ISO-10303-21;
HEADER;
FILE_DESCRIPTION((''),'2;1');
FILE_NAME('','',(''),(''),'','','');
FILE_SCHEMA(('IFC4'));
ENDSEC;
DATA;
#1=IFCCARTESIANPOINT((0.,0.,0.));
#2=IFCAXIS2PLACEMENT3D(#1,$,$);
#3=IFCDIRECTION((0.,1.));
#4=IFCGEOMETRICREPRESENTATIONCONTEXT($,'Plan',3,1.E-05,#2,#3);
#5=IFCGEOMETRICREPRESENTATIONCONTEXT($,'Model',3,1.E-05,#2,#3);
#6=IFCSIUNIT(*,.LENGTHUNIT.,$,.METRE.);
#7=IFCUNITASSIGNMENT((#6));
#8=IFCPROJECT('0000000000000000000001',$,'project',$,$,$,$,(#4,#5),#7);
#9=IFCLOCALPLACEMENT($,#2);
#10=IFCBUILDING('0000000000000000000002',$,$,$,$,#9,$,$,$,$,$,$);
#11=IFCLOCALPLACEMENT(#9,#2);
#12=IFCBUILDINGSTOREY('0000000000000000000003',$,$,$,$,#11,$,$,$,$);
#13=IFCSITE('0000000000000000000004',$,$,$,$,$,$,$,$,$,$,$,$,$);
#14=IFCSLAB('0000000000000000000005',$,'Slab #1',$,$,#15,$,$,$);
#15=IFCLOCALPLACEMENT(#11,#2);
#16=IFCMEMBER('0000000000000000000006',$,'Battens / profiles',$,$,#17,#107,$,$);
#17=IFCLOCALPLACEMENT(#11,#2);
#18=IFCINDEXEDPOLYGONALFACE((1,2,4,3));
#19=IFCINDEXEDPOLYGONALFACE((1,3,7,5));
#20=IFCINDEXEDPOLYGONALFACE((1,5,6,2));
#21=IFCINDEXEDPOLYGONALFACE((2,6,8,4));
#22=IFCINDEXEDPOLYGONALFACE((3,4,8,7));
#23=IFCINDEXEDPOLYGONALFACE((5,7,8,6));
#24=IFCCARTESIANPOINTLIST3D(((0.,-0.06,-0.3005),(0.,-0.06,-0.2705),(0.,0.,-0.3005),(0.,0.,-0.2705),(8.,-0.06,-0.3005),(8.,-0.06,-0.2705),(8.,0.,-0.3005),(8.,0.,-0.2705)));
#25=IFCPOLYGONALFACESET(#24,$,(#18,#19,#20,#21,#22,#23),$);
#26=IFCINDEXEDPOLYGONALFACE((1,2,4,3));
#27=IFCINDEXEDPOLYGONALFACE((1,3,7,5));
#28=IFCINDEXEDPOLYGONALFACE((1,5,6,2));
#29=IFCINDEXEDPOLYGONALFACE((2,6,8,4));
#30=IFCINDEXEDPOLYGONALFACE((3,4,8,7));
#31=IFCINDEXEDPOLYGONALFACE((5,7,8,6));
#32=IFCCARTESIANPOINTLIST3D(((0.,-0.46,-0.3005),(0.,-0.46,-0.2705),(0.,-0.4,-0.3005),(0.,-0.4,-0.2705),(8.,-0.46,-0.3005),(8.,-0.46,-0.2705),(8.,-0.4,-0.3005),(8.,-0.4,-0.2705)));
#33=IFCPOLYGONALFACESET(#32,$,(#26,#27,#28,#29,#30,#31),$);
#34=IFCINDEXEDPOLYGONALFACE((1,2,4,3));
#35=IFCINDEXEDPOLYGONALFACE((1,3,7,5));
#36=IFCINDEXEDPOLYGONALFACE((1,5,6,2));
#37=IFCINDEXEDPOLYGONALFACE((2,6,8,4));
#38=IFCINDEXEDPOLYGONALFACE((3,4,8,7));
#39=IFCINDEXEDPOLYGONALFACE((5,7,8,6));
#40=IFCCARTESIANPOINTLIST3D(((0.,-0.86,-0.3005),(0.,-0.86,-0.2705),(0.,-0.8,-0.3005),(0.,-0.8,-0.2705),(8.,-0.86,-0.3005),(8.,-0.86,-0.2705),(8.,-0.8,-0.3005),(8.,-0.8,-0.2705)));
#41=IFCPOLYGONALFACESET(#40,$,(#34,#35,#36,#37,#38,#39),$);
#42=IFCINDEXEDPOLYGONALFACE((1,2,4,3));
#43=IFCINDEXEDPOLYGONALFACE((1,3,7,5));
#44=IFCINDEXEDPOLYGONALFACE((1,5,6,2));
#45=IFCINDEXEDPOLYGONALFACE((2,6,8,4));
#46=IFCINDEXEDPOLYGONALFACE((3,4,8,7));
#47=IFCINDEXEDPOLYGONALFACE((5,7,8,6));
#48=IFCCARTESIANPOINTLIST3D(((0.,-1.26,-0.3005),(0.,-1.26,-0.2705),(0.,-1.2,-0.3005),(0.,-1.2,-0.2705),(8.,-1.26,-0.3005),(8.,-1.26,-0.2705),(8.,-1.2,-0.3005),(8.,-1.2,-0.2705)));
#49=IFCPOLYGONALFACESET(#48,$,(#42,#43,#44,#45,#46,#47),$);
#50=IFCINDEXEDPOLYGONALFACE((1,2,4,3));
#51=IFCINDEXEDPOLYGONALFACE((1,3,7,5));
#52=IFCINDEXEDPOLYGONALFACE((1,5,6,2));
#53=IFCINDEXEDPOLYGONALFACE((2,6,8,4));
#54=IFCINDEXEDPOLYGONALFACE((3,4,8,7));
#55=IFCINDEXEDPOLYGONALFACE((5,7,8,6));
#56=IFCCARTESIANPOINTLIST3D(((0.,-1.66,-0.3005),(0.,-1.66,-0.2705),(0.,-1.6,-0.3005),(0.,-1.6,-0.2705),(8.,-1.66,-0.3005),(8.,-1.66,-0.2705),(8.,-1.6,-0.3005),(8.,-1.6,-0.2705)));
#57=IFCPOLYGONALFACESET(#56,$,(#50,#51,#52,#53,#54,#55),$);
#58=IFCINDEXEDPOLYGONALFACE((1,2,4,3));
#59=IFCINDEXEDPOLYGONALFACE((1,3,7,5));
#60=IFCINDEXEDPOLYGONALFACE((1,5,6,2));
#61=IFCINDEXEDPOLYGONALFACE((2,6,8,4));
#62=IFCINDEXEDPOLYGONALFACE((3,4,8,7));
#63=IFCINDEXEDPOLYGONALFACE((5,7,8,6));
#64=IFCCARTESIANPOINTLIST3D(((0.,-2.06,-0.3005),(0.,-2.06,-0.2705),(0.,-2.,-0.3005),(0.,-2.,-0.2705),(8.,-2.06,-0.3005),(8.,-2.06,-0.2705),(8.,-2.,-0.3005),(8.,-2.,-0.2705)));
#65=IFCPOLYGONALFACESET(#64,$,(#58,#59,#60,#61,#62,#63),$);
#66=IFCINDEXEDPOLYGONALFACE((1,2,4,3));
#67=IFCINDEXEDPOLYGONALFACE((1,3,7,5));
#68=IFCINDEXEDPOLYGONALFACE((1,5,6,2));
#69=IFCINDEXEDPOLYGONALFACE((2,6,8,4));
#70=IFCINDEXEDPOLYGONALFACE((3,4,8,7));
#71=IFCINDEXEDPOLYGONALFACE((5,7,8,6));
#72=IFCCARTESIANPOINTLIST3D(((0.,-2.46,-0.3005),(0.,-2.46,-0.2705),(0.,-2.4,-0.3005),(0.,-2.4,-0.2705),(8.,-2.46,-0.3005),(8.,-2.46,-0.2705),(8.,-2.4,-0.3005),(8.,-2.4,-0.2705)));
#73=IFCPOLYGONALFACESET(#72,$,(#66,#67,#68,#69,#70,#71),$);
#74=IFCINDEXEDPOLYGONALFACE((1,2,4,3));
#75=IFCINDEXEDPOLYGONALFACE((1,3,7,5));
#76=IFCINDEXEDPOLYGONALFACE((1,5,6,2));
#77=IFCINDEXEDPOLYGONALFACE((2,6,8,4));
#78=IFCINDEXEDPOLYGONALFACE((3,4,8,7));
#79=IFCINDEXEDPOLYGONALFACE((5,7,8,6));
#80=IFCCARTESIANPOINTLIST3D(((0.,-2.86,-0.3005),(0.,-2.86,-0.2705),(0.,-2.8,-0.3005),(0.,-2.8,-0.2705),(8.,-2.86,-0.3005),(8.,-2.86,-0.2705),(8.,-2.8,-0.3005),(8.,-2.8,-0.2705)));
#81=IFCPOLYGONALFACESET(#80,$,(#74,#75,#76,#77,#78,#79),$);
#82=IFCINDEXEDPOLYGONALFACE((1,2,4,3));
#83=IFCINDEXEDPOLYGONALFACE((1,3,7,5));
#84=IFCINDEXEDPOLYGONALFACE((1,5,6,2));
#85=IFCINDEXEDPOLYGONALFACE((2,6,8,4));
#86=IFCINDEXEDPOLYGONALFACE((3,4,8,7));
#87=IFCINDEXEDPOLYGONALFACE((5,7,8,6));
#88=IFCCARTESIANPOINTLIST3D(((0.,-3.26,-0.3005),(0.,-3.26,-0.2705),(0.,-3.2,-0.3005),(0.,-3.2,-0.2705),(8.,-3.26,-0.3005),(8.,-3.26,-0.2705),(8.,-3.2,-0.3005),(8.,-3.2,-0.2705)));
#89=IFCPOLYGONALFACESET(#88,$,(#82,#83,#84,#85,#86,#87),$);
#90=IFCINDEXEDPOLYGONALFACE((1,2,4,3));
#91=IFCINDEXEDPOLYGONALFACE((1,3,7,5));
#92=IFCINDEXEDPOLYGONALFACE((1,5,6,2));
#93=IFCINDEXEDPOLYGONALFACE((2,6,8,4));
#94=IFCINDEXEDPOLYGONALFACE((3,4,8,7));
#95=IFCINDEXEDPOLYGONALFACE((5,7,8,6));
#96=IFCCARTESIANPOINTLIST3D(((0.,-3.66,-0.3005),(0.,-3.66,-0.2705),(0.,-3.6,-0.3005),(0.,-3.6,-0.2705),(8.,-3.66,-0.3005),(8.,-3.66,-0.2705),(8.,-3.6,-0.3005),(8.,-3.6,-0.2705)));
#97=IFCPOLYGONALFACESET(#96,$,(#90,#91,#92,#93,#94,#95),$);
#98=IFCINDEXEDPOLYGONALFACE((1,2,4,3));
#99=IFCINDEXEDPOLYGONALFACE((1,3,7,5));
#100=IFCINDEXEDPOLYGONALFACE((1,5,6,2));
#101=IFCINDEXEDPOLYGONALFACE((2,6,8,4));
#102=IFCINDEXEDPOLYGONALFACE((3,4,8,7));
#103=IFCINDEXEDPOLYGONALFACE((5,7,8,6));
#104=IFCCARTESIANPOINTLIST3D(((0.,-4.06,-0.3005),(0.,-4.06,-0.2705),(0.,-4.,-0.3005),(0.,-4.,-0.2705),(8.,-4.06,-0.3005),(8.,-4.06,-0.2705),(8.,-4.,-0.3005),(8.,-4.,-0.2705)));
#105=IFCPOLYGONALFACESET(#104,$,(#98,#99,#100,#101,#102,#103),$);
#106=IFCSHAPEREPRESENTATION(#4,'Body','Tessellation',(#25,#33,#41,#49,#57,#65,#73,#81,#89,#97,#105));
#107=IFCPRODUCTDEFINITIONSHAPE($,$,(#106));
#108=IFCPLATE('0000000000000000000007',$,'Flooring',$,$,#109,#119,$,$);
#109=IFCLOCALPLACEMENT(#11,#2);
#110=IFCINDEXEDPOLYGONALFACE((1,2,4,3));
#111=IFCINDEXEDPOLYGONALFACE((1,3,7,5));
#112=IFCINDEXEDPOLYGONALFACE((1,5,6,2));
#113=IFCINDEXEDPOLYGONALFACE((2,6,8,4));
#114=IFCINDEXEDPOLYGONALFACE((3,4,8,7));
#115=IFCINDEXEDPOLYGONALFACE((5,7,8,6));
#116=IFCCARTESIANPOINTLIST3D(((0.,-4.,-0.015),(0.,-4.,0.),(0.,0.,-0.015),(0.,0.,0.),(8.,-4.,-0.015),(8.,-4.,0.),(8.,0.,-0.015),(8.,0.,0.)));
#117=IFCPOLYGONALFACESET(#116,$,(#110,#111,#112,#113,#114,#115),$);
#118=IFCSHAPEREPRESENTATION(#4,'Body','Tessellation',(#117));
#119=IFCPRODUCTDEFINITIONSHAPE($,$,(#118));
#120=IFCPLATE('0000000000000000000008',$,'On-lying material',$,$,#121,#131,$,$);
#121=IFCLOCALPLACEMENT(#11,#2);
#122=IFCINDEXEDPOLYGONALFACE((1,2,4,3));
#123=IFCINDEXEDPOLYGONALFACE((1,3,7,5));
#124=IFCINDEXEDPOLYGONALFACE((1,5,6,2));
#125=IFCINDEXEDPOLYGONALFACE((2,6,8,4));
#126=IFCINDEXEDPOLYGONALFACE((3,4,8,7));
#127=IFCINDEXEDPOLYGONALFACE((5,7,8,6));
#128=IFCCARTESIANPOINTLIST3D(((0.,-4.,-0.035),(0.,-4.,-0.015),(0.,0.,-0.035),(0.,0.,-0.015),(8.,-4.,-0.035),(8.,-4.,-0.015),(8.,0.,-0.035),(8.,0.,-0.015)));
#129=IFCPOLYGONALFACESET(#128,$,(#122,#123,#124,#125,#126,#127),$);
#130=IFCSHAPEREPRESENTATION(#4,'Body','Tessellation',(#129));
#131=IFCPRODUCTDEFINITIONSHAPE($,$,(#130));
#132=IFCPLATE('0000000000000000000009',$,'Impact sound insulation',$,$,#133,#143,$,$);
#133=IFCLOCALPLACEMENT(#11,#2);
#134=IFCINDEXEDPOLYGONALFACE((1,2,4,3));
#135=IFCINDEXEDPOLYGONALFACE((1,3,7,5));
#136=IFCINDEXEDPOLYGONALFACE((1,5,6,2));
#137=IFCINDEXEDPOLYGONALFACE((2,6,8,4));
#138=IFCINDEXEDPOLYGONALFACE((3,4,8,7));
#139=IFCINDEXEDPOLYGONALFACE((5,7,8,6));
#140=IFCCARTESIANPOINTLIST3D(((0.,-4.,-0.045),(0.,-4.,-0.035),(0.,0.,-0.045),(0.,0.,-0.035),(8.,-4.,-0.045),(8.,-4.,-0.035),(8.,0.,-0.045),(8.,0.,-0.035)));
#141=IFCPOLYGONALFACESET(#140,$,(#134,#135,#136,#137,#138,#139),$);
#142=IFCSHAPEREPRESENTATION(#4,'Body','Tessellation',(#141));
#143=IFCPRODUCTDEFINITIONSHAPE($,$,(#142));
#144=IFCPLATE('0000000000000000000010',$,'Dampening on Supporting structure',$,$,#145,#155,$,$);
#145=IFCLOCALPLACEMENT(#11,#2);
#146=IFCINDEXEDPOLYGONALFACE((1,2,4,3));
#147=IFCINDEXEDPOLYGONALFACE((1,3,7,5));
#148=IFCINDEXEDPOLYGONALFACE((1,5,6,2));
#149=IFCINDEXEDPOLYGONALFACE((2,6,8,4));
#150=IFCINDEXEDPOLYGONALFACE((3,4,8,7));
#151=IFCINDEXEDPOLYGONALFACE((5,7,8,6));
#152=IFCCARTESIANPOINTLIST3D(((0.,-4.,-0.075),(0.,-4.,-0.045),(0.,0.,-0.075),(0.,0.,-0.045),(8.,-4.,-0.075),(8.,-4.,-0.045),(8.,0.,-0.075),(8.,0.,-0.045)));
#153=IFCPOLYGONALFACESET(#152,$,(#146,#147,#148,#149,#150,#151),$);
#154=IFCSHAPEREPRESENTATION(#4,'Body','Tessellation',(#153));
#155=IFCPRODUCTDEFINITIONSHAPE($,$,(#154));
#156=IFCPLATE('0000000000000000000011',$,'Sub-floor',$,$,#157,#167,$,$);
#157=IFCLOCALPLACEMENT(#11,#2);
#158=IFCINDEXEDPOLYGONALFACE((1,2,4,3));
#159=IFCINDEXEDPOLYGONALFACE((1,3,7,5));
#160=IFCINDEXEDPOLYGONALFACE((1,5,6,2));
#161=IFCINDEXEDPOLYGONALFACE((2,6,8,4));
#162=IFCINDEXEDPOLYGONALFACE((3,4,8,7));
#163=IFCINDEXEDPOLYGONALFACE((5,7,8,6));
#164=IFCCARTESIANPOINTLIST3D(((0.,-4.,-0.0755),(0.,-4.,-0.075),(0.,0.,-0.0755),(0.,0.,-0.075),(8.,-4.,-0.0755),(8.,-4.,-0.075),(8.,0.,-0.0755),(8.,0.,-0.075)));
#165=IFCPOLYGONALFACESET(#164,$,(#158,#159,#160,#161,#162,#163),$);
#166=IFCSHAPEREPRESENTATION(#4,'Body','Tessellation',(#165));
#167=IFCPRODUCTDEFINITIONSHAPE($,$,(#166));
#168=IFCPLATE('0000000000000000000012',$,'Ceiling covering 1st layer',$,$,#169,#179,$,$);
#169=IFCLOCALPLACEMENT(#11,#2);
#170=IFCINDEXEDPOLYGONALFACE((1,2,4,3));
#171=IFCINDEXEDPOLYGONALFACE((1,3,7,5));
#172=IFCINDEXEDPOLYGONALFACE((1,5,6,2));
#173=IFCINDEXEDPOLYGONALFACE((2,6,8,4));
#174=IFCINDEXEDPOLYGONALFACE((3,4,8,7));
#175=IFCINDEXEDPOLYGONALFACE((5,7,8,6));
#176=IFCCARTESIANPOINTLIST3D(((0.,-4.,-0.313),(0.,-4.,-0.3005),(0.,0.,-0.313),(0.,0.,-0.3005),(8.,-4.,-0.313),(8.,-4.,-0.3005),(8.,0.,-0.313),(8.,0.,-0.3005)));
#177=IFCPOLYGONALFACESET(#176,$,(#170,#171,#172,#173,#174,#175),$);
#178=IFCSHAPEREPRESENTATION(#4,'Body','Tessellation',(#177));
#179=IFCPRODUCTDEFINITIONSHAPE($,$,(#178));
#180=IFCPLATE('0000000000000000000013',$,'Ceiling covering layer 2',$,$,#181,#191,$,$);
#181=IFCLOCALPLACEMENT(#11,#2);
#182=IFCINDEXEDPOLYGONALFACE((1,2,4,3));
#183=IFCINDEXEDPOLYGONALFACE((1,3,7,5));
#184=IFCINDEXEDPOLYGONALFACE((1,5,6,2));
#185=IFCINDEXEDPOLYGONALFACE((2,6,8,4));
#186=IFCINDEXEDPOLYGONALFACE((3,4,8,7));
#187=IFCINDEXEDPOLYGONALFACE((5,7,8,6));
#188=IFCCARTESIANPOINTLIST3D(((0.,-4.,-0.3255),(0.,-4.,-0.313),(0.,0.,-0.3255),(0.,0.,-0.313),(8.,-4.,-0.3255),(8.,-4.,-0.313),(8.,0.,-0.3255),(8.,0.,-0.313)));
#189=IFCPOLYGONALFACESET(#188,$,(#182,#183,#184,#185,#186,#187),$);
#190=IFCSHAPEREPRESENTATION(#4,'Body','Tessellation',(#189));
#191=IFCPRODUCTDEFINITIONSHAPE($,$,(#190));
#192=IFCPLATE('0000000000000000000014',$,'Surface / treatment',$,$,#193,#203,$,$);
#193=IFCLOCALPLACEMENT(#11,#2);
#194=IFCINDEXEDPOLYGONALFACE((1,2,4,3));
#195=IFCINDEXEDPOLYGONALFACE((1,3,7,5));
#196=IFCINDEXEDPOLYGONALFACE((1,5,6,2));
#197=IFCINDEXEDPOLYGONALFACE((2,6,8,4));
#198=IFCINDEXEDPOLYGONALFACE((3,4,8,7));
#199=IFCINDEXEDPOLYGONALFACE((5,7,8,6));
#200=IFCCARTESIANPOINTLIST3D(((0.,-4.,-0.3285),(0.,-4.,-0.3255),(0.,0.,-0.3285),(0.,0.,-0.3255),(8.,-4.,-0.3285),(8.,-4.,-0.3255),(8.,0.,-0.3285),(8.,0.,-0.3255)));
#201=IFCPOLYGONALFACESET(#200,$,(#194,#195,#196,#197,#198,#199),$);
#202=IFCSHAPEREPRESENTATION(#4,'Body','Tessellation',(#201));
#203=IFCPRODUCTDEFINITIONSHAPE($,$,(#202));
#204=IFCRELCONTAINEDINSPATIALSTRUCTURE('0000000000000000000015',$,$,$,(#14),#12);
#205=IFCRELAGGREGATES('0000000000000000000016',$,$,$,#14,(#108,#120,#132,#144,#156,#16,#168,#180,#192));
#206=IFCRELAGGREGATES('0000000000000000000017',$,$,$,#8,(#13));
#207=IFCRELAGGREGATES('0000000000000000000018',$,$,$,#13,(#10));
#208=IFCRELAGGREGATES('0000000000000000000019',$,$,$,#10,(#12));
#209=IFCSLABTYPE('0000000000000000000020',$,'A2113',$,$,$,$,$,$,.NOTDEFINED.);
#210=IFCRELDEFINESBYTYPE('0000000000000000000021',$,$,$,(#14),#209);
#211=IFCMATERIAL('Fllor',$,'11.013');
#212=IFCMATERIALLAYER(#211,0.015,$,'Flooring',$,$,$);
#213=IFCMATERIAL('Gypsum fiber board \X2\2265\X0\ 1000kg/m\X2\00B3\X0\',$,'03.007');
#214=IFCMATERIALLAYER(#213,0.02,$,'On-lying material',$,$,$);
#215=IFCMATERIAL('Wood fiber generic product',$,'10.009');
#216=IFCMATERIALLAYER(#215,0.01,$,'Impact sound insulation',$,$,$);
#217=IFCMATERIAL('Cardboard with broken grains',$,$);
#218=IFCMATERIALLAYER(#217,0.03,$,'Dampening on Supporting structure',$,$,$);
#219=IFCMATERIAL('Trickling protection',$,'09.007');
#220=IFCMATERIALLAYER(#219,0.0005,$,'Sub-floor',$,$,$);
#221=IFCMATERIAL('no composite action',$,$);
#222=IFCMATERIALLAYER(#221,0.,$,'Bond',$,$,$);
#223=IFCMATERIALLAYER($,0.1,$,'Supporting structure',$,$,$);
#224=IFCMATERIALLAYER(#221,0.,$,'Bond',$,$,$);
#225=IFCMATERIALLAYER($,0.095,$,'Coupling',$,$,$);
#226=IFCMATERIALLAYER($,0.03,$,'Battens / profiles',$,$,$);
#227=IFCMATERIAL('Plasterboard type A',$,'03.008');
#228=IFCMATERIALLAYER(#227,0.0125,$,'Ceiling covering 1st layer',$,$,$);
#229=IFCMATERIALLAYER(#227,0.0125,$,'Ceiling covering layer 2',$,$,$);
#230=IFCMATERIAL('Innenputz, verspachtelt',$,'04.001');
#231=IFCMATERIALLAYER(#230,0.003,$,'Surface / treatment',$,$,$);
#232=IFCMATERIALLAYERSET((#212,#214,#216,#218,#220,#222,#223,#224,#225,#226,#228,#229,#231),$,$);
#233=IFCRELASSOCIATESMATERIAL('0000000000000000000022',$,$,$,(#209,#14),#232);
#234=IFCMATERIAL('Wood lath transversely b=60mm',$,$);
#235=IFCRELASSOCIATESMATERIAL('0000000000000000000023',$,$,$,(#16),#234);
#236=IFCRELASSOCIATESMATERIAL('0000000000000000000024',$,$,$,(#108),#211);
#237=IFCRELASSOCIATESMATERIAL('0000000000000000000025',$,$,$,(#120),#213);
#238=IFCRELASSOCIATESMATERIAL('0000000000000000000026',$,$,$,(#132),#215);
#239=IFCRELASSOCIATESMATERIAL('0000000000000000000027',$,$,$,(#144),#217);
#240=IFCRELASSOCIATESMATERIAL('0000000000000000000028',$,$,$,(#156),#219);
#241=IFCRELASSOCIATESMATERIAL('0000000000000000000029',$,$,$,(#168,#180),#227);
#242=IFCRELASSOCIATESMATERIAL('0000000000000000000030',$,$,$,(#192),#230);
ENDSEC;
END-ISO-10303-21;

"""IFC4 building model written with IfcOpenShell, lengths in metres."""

from ifc_helpers import new_model, si_unit, direction, frame, frame_2d, origin, origin_with_axes, place, context, project, spatial, rectangle, extrude, material, layer, layer_set, type_object, element, aggregate, save


model = new_model("IFC4")

# Units and contexts
plan_context = context("Plan", 3, precision=1e-05, world=origin(), true_north=direction((0.0, 1.0)))
model_context = context("Model", 3, precision=1e-05, world=origin(), true_north=direction((0.0, 1.0)))
ifc_project = project(units=[si_unit("LENGTHUNIT", "METRE")], contexts=[plan_context, model_context])

# Site, building, storey
site = spatial("IfcSite", under=ifc_project)
building_placement = place(None, origin())
building = spatial("IfcBuilding", under=site, at=building_placement)
storey_placement = place(building_placement, origin())
storey = spatial("IfcBuildingStorey", under=building, at=storey_placement)

# Slab, member, plates
ifc_material_1 = material(Name="Fllor", Category="11.013")
ifc_layer_1 = layer(ifc_material_1, 0.015, Name="Flooring")
ifc_material_2 = material(Name="Gypsum fiber board ≥ 1000kg/m³", Category="03.007")
ifc_layer_2 = layer(ifc_material_2, 0.02, Name="On-lying material")
ifc_material_3 = material(Name="Wood fiber generic product", Category="10.009")
ifc_layer_3 = layer(ifc_material_3, 0.01, Name="Impact sound insulation")
ifc_material_4 = material(Name="Cardboard with broken grains")
ifc_layer_4 = layer(ifc_material_4, 0.03, Name="Dampening on Supporting structure")
ifc_material_5 = material(Name="Trickling protection", Category="09.007")
ifc_layer_5 = layer(ifc_material_5, 0.0005, Name="Sub-floor")
ifc_material_6 = material(Name="no composite action")
ifc_layer_6 = layer(ifc_material_6, 0.0, Name="Bond")
ifc_layer_7 = layer(None, 0.1, Name="Supporting structure")
ifc_layer_8 = layer(ifc_material_6, 0.0, Name="Bond")
ifc_layer_9 = layer(None, 0.095, Name="Coupling")
ifc_layer_10 = layer(None, 0.03, Name="Battens / profiles")
ifc_material_7 = material(Name="Plasterboard type A", Category="03.008")
ifc_layer_11 = layer(ifc_material_7, 0.0125, Name="Ceiling covering 1st layer")
ifc_layer_12 = layer(ifc_material_7, 0.0125, Name="Ceiling covering layer 2")
ifc_material_8 = material(Name="Innenputz, verspachtelt", Category="04.001")
ifc_layer_13 = layer(ifc_material_8, 0.003, Name="Surface / treatment")
ifc_layer_set = layer_set([ifc_layer_1, ifc_layer_2, ifc_layer_3, ifc_layer_4, ifc_layer_5, ifc_layer_6, ifc_layer_7, ifc_layer_8, ifc_layer_9, ifc_layer_10, ifc_layer_11, ifc_layer_12, ifc_layer_13])
slab_type = type_object("IfcSlabType", Name="A2113", PredefinedType="NOTDEFINED", material=ifc_layer_set)
slab_placement = place(None, frame((0.0, 0.0, 0.0), z_axis=(0.0, 0.0, -1.0), x_axis=(1.0, 0.0, 0.0)))
slab = element("IfcSlab", 1, at=slab_placement, inside=storey, type_object=slab_type, material=ifc_layer_set, Name="Slab #1")
ifc_material_9 = material(Name="Wood lath transversely b=60mm")
member_1_placement = place(slab_placement, origin())
member_1 = element("IfcMember", 2, at=member_1_placement, material=ifc_material_9, Name="Battens / profiles", context=plan_context, shape_type="SweptSolid", body=[
    extrude(rectangle(XDim=0.06, YDim=0.03, at=frame_2d((0.03, 0.015), x_axis=(1.0, 0.0))), frame((0.0, 0.0, 0.2705), z_axis=(1.0, 0.0, 0.0), x_axis=(0.0, 1.0, 0.0)), (0.0, 0.0, 1.0), 8.0),
    extrude(rectangle(XDim=0.06, YDim=0.03, at=frame_2d((0.03, 0.015), x_axis=(1.0, 0.0))), frame((0.0, 0.4, 0.2705), z_axis=(1.0, 0.0, 0.0), x_axis=(0.0, 1.0, 0.0)), (0.0, 0.0, 1.0), 8.0),
    extrude(rectangle(XDim=0.06, YDim=0.03, at=frame_2d((0.03, 0.015), x_axis=(1.0, 0.0))), frame((0.0, 0.8, 0.2705), z_axis=(1.0, 0.0, 0.0), x_axis=(0.0, 1.0, 0.0)), (0.0, 0.0, 1.0), 8.0),
    extrude(rectangle(XDim=0.06, YDim=0.03, at=frame_2d((0.03, 0.015), x_axis=(1.0, 0.0))), frame((0.0, 1.2, 0.2705), z_axis=(1.0, 0.0, 0.0), x_axis=(0.0, 1.0, 0.0)), (0.0, 0.0, 1.0), 8.0),
    extrude(rectangle(XDim=0.06, YDim=0.03, at=frame_2d((0.03, 0.015), x_axis=(1.0, 0.0))), frame((0.0, 1.6, 0.2705), z_axis=(1.0, 0.0, 0.0), x_axis=(0.0, 1.0, 0.0)), (0.0, 0.0, 1.0), 8.0),
    extrude(rectangle(XDim=0.06, YDim=0.03, at=frame_2d((0.03, 0.015), x_axis=(1.0, 0.0))), frame((0.0, 2.0, 0.2705), z_axis=(1.0, 0.0, 0.0), x_axis=(0.0, 1.0, 0.0)), (0.0, 0.0, 1.0), 8.0),
    extrude(rectangle(XDim=0.06, YDim=0.03, at=frame_2d((0.03, 0.015), x_axis=(1.0, 0.0))), frame((0.0, 2.4, 0.2705), z_axis=(1.0, 0.0, 0.0), x_axis=(0.0, 1.0, 0.0)), (0.0, 0.0, 1.0), 8.0),
    extrude(rectangle(XDim=0.06, YDim=0.03, at=frame_2d((0.03, 0.015), x_axis=(1.0, 0.0))), frame((0.0, 2.8, 0.2705), z_axis=(1.0, 0.0, 0.0), x_axis=(0.0, 1.0, 0.0)), (0.0, 0.0, 1.0), 8.0),
    extrude(rectangle(XDim=0.06, YDim=0.03, at=frame_2d((0.03, 0.015), x_axis=(1.0, 0.0))), frame((0.0, 3.2, 0.2705), z_axis=(1.0, 0.0, 0.0), x_axis=(0.0, 1.0, 0.0)), (0.0, 0.0, 1.0), 8.0),
    extrude(rectangle(XDim=0.06, YDim=0.03, at=frame_2d((0.03, 0.015), x_axis=(1.0, 0.0))), frame((0.0, 3.6, 0.2705), z_axis=(1.0, 0.0, 0.0), x_axis=(0.0, 1.0, 0.0)), (0.0, 0.0, 1.0), 8.0),
    extrude(rectangle(XDim=0.06, YDim=0.03, at=frame_2d((0.03, 0.015), x_axis=(1.0, 0.0))), frame((0.0, 4.0, 0.2705), z_axis=(1.0, 0.0, 0.0), x_axis=(0.0, 1.0, 0.0)), (0.0, 0.0, 1.0), 8.0),
])
plate_1_placement = place(slab_placement, origin())
plate_1 = element("IfcPlate", 3, at=plate_1_placement, material=ifc_material_1, Name="Flooring", context=plan_context, shape_type="SweptSolid", body=[
    extrude(rectangle(XDim=8.0, YDim=4.0, at=frame_2d((4.0, 2.0), x_axis=(1.0, 0.0))), origin_with_axes(), (0.0, 0.0, 1.0), 0.015),
])
plate_2_placement = place(slab_placement, origin())
plate_2 = element("IfcPlate", 4, at=plate_2_placement, material=ifc_material_2, Name="On-lying material", context=plan_context, shape_type="SweptSolid", body=[
    extrude(rectangle(XDim=8.0, YDim=4.0, at=frame_2d((4.0, 2.0), x_axis=(1.0, 0.0))), frame((0.0, 0.0, 0.015), z_axis=(0.0, 0.0, 1.0), x_axis=(1.0, 0.0, 0.0)), (0.0, 0.0, 1.0), 0.02),
])
plate_3_placement = place(slab_placement, origin())
plate_3 = element("IfcPlate", 5, at=plate_3_placement, material=ifc_material_3, Name="Impact sound insulation", context=plan_context, shape_type="SweptSolid", body=[
    extrude(rectangle(XDim=8.0, YDim=4.0, at=frame_2d((4.0, 2.0), x_axis=(1.0, 0.0))), frame((0.0, 0.0, 0.035), z_axis=(0.0, 0.0, 1.0), x_axis=(1.0, 0.0, 0.0)), (0.0, 0.0, 1.0), 0.01),
])
plate_4_placement = place(slab_placement, origin())
plate_4 = element("IfcPlate", 6, at=plate_4_placement, material=ifc_material_4, Name="Dampening on Supporting structure", context=plan_context, shape_type="SweptSolid", body=[
    extrude(rectangle(XDim=8.0, YDim=4.0, at=frame_2d((4.0, 2.0), x_axis=(1.0, 0.0))), frame((0.0, 0.0, 0.045), z_axis=(0.0, 0.0, 1.0), x_axis=(1.0, 0.0, 0.0)), (0.0, 0.0, 1.0), 0.03),
])
plate_5_placement = place(slab_placement, origin())
plate_5 = element("IfcPlate", 7, at=plate_5_placement, material=ifc_material_5, Name="Sub-floor", context=plan_context, shape_type="SweptSolid", body=[
    extrude(rectangle(XDim=8.0, YDim=4.0, at=frame_2d((4.0, 2.0), x_axis=(1.0, 0.0))), frame((0.0, 0.0, 0.075), z_axis=(0.0, 0.0, 1.0), x_axis=(1.0, 0.0, 0.0)), (0.0, 0.0, 1.0), 0.0005),
])
plate_6_placement = place(slab_placement, origin())
plate_6 = element("IfcPlate", 8, at=plate_6_placement, material=ifc_material_7, Name="Ceiling covering 1st layer", context=plan_context, shape_type="SweptSolid", body=[
    extrude(rectangle(XDim=8.0, YDim=4.0, at=frame_2d((4.0, 2.0), x_axis=(1.0, 0.0))), frame((0.0, 0.0, 0.3005), z_axis=(0.0, 0.0, 1.0), x_axis=(1.0, 0.0, 0.0)), (0.0, 0.0, 1.0), 0.0125),
])
plate_7_placement = place(slab_placement, origin())
plate_7 = element("IfcPlate", 9, at=plate_7_placement, material=ifc_material_7, Name="Ceiling covering layer 2", context=plan_context, shape_type="SweptSolid", body=[
    extrude(rectangle(XDim=8.0, YDim=4.0, at=frame_2d((4.0, 2.0), x_axis=(1.0, 0.0))), frame((0.0, 0.0, 0.313), z_axis=(0.0, 0.0, 1.0), x_axis=(1.0, 0.0, 0.0)), (0.0, 0.0, 1.0), 0.0125),
])
plate_8_placement = place(slab_placement, origin())
plate_8 = element("IfcPlate", 10, at=plate_8_placement, material=ifc_material_8, Name="Surface / treatment", context=plan_context, shape_type="SweptSolid", body=[
    extrude(rectangle(XDim=8.0, YDim=4.0, at=frame_2d((4.0, 2.0), x_axis=(1.0, 0.0))), frame((0.0, 0.0, 0.3255), z_axis=(0.0, 0.0, 1.0), x_axis=(1.0, 0.0, 0.0)), (0.0, 0.0, 1.0), 0.003),
])
aggregate(slab, [plate_1, plate_2, plate_3, plate_4, plate_5, member_1, plate_6, plate_7, plate_8])

save(model, "model.ifc")
